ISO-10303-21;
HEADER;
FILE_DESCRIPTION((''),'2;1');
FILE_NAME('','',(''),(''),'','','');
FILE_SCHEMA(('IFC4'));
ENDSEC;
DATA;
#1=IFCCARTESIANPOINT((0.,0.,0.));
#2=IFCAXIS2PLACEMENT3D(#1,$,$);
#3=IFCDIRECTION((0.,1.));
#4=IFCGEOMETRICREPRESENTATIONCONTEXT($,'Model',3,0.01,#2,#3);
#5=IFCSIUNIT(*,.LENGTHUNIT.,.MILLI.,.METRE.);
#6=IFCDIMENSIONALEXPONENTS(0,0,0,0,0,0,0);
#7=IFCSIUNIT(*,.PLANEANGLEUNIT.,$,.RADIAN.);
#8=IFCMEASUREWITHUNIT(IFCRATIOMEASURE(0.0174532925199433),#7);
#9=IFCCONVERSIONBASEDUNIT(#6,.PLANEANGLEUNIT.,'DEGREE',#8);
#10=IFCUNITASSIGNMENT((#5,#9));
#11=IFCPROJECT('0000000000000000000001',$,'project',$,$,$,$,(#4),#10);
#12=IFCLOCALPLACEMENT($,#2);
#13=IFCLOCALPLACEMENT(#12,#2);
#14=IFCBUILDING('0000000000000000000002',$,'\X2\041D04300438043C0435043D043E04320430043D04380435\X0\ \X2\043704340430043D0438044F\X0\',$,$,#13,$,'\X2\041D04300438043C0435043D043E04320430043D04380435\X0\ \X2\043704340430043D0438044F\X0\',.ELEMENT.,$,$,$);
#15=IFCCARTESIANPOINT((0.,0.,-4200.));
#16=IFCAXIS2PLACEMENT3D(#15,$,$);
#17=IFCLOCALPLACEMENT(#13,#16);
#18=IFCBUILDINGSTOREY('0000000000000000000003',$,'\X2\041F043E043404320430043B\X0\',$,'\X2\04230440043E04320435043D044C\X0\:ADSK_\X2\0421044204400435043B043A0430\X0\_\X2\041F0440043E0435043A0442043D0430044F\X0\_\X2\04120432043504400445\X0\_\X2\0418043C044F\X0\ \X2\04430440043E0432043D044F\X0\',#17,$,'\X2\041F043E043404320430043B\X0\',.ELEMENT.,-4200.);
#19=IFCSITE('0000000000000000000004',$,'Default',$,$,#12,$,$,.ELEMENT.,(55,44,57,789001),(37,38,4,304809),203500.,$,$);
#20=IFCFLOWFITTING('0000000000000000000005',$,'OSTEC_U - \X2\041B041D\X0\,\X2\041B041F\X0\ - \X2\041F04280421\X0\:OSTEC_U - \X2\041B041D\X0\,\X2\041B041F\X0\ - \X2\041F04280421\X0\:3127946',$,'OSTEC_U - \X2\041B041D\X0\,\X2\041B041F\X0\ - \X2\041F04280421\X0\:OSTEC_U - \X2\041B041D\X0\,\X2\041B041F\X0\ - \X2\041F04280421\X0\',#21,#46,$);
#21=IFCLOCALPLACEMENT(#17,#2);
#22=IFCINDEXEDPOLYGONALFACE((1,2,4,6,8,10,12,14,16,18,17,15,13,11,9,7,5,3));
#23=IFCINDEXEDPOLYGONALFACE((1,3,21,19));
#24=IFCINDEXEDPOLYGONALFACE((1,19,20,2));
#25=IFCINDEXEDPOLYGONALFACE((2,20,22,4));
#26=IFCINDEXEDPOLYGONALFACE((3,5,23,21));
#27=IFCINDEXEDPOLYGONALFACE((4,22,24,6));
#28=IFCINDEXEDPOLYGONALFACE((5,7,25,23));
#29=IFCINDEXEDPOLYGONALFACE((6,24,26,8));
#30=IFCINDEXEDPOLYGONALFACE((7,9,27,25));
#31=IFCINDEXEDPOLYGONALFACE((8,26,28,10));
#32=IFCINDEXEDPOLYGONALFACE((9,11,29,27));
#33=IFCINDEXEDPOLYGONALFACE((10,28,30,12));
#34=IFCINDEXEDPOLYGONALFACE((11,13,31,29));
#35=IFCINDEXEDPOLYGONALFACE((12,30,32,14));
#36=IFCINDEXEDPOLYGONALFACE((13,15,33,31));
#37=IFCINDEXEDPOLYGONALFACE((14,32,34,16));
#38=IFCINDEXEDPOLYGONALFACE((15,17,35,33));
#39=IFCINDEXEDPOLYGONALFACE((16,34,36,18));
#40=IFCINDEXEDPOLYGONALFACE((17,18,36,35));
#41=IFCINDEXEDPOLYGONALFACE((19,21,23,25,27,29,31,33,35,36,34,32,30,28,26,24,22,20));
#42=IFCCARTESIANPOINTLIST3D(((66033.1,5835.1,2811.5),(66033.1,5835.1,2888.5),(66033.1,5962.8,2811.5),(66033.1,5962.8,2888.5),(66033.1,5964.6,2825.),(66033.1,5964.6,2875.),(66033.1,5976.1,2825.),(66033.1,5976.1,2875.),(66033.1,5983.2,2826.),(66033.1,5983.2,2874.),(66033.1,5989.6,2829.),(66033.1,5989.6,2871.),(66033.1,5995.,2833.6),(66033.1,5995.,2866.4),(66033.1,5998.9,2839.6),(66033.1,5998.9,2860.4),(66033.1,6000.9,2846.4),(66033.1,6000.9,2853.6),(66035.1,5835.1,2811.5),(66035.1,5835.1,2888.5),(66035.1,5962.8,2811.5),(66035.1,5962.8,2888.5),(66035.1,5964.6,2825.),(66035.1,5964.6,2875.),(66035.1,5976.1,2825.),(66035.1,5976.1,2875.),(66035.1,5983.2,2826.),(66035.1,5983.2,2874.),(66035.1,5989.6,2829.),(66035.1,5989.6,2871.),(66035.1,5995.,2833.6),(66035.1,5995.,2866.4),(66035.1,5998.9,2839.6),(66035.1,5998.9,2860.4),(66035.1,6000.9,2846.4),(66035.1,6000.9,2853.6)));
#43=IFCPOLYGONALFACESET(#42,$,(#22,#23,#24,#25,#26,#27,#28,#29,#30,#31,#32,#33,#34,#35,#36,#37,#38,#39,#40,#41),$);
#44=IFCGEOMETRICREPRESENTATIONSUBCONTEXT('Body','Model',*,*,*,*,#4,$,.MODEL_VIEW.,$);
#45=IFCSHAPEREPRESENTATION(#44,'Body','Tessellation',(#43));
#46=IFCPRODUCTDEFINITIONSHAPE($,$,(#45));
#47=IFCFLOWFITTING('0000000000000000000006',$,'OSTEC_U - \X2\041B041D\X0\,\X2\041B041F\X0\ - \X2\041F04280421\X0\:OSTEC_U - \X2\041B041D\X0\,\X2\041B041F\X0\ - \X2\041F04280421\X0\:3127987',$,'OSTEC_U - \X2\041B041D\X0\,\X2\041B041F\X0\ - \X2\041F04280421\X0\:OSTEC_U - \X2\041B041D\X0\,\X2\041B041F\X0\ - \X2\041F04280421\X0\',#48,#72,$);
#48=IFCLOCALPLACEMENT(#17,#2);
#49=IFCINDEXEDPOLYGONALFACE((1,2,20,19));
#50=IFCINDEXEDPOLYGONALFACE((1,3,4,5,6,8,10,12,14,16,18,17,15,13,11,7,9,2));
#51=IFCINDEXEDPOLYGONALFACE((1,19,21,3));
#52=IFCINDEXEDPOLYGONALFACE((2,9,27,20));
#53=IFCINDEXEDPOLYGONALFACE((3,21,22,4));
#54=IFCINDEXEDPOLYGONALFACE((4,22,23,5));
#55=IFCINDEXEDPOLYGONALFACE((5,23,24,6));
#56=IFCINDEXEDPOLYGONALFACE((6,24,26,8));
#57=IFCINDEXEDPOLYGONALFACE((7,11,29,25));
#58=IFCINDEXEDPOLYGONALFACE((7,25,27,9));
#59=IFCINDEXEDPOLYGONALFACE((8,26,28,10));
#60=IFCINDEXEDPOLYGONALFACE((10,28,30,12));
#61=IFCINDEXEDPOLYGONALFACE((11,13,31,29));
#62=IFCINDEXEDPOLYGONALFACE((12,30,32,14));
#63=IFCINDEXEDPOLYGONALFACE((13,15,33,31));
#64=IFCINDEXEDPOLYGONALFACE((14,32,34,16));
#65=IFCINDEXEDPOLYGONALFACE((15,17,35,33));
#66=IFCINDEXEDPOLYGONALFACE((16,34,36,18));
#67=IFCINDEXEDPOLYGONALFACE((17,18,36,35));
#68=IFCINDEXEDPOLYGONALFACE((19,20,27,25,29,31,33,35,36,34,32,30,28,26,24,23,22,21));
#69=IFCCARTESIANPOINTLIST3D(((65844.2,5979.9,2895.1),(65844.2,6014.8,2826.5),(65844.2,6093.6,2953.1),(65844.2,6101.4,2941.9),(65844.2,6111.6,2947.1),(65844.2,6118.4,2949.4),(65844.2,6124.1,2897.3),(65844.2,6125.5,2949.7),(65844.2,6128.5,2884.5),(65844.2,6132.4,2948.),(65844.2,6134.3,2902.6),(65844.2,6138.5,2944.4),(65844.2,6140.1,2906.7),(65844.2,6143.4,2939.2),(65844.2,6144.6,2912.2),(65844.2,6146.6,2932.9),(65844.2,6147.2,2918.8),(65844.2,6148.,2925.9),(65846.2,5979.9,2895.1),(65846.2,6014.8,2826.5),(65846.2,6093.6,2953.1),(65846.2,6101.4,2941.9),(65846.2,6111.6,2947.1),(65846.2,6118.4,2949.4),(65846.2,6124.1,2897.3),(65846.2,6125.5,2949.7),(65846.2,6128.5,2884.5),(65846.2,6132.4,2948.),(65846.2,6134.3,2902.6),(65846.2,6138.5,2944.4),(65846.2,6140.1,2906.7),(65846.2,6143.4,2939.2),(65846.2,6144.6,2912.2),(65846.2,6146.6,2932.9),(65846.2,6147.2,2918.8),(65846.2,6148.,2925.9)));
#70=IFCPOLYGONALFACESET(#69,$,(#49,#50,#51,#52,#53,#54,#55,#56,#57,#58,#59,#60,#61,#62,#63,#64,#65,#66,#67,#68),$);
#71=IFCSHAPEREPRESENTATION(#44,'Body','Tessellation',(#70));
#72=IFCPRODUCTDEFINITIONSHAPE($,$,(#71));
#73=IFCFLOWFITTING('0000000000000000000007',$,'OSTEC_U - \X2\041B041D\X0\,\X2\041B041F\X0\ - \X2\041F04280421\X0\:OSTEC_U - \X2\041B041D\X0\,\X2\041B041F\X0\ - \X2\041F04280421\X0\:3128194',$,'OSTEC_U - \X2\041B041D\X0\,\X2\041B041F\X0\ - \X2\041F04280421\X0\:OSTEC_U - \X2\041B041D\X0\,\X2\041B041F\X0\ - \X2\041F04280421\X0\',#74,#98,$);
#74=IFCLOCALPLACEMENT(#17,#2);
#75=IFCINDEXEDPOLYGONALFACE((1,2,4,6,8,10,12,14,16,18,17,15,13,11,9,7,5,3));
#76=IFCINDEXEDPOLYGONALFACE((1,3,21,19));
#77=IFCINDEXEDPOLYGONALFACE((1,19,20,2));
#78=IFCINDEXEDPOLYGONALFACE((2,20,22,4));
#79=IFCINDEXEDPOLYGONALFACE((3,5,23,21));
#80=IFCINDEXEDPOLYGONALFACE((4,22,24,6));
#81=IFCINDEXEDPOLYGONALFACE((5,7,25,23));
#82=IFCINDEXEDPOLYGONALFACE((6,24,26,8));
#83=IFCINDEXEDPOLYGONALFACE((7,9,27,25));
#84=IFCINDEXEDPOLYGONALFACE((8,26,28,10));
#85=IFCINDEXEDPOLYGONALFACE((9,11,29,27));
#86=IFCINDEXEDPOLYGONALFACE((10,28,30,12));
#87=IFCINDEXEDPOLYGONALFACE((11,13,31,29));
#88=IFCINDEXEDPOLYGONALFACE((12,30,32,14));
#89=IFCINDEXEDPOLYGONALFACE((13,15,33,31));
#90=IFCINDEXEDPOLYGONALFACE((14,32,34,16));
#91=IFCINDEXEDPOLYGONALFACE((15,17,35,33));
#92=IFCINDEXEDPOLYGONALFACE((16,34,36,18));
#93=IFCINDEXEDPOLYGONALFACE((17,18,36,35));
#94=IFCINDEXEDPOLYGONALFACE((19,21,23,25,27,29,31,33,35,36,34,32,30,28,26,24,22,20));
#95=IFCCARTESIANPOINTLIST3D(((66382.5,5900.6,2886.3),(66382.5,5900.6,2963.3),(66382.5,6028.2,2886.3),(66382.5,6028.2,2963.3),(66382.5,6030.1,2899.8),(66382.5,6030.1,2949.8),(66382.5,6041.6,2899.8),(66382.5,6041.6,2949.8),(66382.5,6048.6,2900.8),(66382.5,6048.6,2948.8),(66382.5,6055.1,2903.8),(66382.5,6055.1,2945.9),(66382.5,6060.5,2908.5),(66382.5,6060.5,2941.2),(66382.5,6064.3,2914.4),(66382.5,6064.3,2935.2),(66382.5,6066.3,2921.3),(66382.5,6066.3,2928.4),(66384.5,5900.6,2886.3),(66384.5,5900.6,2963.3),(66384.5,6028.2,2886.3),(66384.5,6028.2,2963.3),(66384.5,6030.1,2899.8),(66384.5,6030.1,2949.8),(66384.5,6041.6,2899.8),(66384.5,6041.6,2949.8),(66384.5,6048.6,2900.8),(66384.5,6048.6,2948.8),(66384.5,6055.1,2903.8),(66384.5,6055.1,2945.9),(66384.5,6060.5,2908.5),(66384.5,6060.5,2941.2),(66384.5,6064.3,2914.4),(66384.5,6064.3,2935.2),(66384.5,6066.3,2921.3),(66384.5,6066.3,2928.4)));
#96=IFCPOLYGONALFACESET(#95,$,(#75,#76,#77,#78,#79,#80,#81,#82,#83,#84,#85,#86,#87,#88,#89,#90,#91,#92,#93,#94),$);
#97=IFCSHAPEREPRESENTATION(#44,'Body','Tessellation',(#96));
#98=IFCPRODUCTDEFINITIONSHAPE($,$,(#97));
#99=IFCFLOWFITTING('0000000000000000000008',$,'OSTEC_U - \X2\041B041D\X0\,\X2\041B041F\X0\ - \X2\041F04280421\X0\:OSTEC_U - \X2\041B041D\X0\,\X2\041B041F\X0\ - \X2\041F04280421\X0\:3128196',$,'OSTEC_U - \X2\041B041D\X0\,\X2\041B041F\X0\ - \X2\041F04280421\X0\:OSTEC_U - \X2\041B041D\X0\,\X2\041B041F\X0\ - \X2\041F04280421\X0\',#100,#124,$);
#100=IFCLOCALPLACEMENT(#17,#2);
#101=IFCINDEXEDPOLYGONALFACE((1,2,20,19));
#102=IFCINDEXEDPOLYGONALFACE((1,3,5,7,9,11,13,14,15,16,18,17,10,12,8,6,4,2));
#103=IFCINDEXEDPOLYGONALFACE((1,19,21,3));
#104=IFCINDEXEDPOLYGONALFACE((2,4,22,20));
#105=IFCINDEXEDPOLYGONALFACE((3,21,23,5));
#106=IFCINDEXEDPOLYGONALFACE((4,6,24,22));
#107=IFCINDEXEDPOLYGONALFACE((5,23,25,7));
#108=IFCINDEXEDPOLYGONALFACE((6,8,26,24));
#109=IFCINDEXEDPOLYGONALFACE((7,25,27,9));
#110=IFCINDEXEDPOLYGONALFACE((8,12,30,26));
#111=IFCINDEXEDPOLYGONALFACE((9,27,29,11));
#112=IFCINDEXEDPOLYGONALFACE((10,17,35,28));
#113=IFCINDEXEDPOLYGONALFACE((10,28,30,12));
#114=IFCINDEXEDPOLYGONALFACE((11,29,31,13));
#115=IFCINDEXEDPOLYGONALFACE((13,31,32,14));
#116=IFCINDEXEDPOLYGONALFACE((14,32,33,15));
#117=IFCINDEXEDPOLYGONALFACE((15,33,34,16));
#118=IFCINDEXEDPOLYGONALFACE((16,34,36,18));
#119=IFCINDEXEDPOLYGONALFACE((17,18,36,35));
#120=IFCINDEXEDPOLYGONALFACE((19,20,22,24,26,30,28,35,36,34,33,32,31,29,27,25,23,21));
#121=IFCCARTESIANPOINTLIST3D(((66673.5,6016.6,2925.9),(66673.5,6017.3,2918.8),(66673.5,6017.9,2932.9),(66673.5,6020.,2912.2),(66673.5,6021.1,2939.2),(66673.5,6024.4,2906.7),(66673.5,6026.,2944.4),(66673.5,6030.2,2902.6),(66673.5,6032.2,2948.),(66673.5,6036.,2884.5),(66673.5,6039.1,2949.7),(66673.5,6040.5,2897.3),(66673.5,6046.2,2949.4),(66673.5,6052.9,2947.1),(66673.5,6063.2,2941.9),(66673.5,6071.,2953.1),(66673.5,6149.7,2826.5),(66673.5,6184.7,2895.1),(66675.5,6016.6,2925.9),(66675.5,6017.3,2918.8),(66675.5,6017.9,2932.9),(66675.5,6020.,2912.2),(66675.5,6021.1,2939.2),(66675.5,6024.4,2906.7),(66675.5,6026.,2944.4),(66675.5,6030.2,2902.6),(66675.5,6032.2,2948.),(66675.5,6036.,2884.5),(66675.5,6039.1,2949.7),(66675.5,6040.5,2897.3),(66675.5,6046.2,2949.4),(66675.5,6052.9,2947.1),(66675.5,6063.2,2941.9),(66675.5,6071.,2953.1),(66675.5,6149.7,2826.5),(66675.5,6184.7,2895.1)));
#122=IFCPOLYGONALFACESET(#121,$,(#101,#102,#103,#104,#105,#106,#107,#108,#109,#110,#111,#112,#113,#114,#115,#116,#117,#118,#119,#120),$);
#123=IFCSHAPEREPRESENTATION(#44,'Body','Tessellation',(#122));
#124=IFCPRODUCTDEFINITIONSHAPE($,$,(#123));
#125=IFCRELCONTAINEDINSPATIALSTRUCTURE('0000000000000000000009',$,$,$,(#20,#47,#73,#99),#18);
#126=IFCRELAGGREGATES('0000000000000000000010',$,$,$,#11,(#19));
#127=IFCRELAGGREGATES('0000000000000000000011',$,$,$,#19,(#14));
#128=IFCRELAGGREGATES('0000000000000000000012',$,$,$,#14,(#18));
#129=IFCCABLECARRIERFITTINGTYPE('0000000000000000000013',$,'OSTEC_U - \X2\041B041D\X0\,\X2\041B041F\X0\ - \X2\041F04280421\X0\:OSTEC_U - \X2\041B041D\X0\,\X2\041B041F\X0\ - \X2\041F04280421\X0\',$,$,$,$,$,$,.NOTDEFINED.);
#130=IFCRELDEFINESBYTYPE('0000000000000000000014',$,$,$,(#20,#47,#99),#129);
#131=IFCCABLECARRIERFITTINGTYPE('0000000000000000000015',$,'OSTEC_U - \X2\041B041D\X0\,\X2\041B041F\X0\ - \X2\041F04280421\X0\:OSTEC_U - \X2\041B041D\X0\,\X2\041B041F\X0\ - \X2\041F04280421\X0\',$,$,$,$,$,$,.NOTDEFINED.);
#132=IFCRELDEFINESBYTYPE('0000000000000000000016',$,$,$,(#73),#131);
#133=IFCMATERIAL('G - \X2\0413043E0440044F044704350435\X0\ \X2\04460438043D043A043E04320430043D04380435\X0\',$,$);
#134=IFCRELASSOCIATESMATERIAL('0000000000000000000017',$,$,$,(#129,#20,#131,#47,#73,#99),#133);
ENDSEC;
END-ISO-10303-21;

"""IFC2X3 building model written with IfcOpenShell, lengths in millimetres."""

from ifc_helpers import new_model, entity, si_unit, converted_unit, direction, frame, frame_2d, origin, place, context, subcontext, project, spatial, polyline, circle_curve, parameter, trimmed, segment, composite_curve, outline, extrude, source, transform, mapped, material, type_object, type_shapes, element, save


model = new_model("IFC2X3")

# Units and contexts
model_context = context("Model", 3, precision=0.01, world=origin(), true_north=direction((0.0, 1.0)))
body_context = subcontext(model_context, "Body", "Model", "MODEL_VIEW")
ifc_project = project(units=[si_unit("LENGTHUNIT", "METRE", prefix="MILLI"), converted_unit("PLANEANGLEUNIT", "DEGREE", entity("IfcRatioMeasure", 0.0174532925199433), si_unit("PLANEANGLEUNIT", "RADIAN"), dimensions=[0, 0, 0, 0, 0, 0, 0])], contexts=[model_context])

# Site, building, storey
site_placement = place(None, origin())
site = spatial("IfcSite", under=ifc_project, at=site_placement, Name="Default", CompositionType="ELEMENT", RefLatitude=(55, 44, 57, 789001), RefLongitude=(37, 38, 4, 304809), RefElevation=203500.0)
building_placement = place(site_placement, origin())
building = spatial("IfcBuilding", under=site, at=building_placement, Name="Наименование здания", LongName="Наименование здания", CompositionType="ELEMENT")
storey_placement = place(building_placement, frame((0.0, 0.0, -4200.0)))
storey = spatial("IfcBuildingStorey", under=building, at=storey_placement, Name="Подвал", ObjectType="Уровень:ADSK_Стрелка_Проектная_Вверх_Имя уровня", LongName="Подвал", CompositionType="ELEMENT", Elevation=-4200.0)

# Flow fittings
ifc_material = material(Name="G - Горячее цинкование")
shared_shape_1 = source(origin(), body_context, "Body", "SweptSolid", [
    extrude(outline(composite_curve([segment(trimmed(circle_curve(frame_2d((-41.5, 0.0), x_axis=(1.0, 0.0)), 25.0), [parameter(90.0)], [parameter(270.0)], True, "PARAMETER"), True, "CONTINUOUS"), segment(polyline([(-41.5, -25.0), (-30.0, -25.0)]), True, "CONTINUOUS"), segment(polyline([(-30.0, -25.0), (-28.1, -38.5)]), True, "CONTINUOUS"), segment(polyline([(-28.1, -38.5), (99.5, -38.5)]), True, "CONTINUOUS"), segment(polyline([(99.5, -38.5), (99.5, 38.5)]), True, "CONTINUOUS"), segment(polyline([(99.5, 38.5), (-28.1, 38.5)]), True, "CONTINUOUS"), segment(polyline([(-28.1, 38.5), (-30.0, 25.0)]), True, "CONTINUOUS"), segment(polyline([(-30.0, 25.0), (-41.5, 25.0)]), True, "CONTINUOUS")], self_intersect=False)), frame((41.5, 0.0, 0.0)), (0.0, 0.0, 1.0), 2.0),
])
cable_carrier_fitting_type_1 = type_object("IfcCableCarrierFittingType", Name="OSTEC_U - ЛН,ЛП - ПШС:OSTEC_U - ЛН,ЛП - ПШС", PredefinedType="NOTDEFINED", material=ifc_material)
type_shapes(cable_carrier_fitting_type_1, [shared_shape_1])
flow_fitting_1_placement = place(storey_placement, frame((66033.1, 5976.1, 2850.0), z_axis=(1.0, 0.0, 0.0), x_axis=(0.0, -1.0, 0.0)))
element("IfcFlowFitting", 1, at=flow_fitting_1_placement, inside=storey, type_object=cable_carrier_fitting_type_1, material=ifc_material, Name="OSTEC_U - ЛН,ЛП - ПШС:OSTEC_U - ЛН,ЛП - ПШС:3127946", ObjectType="OSTEC_U - ЛН,ЛП - ПШС:OSTEC_U - ЛН,ЛП - ПШС", context=body_context, shape_type="MappedRepresentation", body=[
    mapped(shared_shape_1, transform((0.0, 0.0, 0.0), scale=1.0)),
])
cable_carrier_fitting_type_2 = type_object("IfcCableCarrierFittingType", Name="OSTEC_U - ЛН,ЛП - ПШС:OSTEC_U - ЛН,ЛП - ПШС", PredefinedType="NOTDEFINED", material=ifc_material)
type_shapes(cable_carrier_fitting_type_2, [shared_shape_1])
flow_fitting_2_placement = place(storey_placement, frame((65846.2, 6123.0, 2924.8), z_axis=(-1.0, 0.0, 0.0), x_axis=(0.0, -0.891007, -0.45399)))
element("IfcFlowFitting", 2, at=flow_fitting_2_placement, inside=storey, type_object=cable_carrier_fitting_type_1, material=ifc_material, Name="OSTEC_U - ЛН,ЛП - ПШС:OSTEC_U - ЛН,ЛП - ПШС:3127987", ObjectType="OSTEC_U - ЛН,ЛП - ПШС:OSTEC_U - ЛН,ЛП - ПШС", context=body_context, shape_type="MappedRepresentation", body=[
    mapped(shared_shape_1, transform((0.0, 0.0, 0.0), scale=1.0)),
])
flow_fitting_3_placement = place(storey_placement, frame((66384.5, 6041.6, 2924.8), z_axis=(-1.0, 0.0, 0.0), x_axis=(0.0, -1.0, 0.0)))
element("IfcFlowFitting", 3, at=flow_fitting_3_placement, inside=storey, type_object=cable_carrier_fitting_type_2, material=ifc_material, Name="OSTEC_U - ЛН,ЛП - ПШС:OSTEC_U - ЛН,ЛП - ПШС:3128194", ObjectType="OSTEC_U - ЛН,ЛП - ПШС:OSTEC_U - ЛН,ЛП - ПШС", context=body_context, shape_type="MappedRepresentation", body=[
    mapped(shared_shape_1, transform((0.0, 0.0, 0.0), scale=1.0)),
])
flow_fitting_4_placement = place(storey_placement, frame((66673.5, 6041.6, 2924.8), z_axis=(1.0, 0.0, 0.0), x_axis=(0.0, 0.891007, -0.45399)))
element("IfcFlowFitting", 4, at=flow_fitting_4_placement, inside=storey, type_object=cable_carrier_fitting_type_1, material=ifc_material, Name="OSTEC_U - ЛН,ЛП - ПШС:OSTEC_U - ЛН,ЛП - ПШС:3128196", ObjectType="OSTEC_U - ЛН,ЛП - ПШС:OSTEC_U - ЛН,ЛП - ПШС", context=body_context, shape_type="MappedRepresentation", body=[
    mapped(shared_shape_1, transform((0.0, 0.0, 0.0), scale=1.0)),
])

save(model, "model.ifc")
